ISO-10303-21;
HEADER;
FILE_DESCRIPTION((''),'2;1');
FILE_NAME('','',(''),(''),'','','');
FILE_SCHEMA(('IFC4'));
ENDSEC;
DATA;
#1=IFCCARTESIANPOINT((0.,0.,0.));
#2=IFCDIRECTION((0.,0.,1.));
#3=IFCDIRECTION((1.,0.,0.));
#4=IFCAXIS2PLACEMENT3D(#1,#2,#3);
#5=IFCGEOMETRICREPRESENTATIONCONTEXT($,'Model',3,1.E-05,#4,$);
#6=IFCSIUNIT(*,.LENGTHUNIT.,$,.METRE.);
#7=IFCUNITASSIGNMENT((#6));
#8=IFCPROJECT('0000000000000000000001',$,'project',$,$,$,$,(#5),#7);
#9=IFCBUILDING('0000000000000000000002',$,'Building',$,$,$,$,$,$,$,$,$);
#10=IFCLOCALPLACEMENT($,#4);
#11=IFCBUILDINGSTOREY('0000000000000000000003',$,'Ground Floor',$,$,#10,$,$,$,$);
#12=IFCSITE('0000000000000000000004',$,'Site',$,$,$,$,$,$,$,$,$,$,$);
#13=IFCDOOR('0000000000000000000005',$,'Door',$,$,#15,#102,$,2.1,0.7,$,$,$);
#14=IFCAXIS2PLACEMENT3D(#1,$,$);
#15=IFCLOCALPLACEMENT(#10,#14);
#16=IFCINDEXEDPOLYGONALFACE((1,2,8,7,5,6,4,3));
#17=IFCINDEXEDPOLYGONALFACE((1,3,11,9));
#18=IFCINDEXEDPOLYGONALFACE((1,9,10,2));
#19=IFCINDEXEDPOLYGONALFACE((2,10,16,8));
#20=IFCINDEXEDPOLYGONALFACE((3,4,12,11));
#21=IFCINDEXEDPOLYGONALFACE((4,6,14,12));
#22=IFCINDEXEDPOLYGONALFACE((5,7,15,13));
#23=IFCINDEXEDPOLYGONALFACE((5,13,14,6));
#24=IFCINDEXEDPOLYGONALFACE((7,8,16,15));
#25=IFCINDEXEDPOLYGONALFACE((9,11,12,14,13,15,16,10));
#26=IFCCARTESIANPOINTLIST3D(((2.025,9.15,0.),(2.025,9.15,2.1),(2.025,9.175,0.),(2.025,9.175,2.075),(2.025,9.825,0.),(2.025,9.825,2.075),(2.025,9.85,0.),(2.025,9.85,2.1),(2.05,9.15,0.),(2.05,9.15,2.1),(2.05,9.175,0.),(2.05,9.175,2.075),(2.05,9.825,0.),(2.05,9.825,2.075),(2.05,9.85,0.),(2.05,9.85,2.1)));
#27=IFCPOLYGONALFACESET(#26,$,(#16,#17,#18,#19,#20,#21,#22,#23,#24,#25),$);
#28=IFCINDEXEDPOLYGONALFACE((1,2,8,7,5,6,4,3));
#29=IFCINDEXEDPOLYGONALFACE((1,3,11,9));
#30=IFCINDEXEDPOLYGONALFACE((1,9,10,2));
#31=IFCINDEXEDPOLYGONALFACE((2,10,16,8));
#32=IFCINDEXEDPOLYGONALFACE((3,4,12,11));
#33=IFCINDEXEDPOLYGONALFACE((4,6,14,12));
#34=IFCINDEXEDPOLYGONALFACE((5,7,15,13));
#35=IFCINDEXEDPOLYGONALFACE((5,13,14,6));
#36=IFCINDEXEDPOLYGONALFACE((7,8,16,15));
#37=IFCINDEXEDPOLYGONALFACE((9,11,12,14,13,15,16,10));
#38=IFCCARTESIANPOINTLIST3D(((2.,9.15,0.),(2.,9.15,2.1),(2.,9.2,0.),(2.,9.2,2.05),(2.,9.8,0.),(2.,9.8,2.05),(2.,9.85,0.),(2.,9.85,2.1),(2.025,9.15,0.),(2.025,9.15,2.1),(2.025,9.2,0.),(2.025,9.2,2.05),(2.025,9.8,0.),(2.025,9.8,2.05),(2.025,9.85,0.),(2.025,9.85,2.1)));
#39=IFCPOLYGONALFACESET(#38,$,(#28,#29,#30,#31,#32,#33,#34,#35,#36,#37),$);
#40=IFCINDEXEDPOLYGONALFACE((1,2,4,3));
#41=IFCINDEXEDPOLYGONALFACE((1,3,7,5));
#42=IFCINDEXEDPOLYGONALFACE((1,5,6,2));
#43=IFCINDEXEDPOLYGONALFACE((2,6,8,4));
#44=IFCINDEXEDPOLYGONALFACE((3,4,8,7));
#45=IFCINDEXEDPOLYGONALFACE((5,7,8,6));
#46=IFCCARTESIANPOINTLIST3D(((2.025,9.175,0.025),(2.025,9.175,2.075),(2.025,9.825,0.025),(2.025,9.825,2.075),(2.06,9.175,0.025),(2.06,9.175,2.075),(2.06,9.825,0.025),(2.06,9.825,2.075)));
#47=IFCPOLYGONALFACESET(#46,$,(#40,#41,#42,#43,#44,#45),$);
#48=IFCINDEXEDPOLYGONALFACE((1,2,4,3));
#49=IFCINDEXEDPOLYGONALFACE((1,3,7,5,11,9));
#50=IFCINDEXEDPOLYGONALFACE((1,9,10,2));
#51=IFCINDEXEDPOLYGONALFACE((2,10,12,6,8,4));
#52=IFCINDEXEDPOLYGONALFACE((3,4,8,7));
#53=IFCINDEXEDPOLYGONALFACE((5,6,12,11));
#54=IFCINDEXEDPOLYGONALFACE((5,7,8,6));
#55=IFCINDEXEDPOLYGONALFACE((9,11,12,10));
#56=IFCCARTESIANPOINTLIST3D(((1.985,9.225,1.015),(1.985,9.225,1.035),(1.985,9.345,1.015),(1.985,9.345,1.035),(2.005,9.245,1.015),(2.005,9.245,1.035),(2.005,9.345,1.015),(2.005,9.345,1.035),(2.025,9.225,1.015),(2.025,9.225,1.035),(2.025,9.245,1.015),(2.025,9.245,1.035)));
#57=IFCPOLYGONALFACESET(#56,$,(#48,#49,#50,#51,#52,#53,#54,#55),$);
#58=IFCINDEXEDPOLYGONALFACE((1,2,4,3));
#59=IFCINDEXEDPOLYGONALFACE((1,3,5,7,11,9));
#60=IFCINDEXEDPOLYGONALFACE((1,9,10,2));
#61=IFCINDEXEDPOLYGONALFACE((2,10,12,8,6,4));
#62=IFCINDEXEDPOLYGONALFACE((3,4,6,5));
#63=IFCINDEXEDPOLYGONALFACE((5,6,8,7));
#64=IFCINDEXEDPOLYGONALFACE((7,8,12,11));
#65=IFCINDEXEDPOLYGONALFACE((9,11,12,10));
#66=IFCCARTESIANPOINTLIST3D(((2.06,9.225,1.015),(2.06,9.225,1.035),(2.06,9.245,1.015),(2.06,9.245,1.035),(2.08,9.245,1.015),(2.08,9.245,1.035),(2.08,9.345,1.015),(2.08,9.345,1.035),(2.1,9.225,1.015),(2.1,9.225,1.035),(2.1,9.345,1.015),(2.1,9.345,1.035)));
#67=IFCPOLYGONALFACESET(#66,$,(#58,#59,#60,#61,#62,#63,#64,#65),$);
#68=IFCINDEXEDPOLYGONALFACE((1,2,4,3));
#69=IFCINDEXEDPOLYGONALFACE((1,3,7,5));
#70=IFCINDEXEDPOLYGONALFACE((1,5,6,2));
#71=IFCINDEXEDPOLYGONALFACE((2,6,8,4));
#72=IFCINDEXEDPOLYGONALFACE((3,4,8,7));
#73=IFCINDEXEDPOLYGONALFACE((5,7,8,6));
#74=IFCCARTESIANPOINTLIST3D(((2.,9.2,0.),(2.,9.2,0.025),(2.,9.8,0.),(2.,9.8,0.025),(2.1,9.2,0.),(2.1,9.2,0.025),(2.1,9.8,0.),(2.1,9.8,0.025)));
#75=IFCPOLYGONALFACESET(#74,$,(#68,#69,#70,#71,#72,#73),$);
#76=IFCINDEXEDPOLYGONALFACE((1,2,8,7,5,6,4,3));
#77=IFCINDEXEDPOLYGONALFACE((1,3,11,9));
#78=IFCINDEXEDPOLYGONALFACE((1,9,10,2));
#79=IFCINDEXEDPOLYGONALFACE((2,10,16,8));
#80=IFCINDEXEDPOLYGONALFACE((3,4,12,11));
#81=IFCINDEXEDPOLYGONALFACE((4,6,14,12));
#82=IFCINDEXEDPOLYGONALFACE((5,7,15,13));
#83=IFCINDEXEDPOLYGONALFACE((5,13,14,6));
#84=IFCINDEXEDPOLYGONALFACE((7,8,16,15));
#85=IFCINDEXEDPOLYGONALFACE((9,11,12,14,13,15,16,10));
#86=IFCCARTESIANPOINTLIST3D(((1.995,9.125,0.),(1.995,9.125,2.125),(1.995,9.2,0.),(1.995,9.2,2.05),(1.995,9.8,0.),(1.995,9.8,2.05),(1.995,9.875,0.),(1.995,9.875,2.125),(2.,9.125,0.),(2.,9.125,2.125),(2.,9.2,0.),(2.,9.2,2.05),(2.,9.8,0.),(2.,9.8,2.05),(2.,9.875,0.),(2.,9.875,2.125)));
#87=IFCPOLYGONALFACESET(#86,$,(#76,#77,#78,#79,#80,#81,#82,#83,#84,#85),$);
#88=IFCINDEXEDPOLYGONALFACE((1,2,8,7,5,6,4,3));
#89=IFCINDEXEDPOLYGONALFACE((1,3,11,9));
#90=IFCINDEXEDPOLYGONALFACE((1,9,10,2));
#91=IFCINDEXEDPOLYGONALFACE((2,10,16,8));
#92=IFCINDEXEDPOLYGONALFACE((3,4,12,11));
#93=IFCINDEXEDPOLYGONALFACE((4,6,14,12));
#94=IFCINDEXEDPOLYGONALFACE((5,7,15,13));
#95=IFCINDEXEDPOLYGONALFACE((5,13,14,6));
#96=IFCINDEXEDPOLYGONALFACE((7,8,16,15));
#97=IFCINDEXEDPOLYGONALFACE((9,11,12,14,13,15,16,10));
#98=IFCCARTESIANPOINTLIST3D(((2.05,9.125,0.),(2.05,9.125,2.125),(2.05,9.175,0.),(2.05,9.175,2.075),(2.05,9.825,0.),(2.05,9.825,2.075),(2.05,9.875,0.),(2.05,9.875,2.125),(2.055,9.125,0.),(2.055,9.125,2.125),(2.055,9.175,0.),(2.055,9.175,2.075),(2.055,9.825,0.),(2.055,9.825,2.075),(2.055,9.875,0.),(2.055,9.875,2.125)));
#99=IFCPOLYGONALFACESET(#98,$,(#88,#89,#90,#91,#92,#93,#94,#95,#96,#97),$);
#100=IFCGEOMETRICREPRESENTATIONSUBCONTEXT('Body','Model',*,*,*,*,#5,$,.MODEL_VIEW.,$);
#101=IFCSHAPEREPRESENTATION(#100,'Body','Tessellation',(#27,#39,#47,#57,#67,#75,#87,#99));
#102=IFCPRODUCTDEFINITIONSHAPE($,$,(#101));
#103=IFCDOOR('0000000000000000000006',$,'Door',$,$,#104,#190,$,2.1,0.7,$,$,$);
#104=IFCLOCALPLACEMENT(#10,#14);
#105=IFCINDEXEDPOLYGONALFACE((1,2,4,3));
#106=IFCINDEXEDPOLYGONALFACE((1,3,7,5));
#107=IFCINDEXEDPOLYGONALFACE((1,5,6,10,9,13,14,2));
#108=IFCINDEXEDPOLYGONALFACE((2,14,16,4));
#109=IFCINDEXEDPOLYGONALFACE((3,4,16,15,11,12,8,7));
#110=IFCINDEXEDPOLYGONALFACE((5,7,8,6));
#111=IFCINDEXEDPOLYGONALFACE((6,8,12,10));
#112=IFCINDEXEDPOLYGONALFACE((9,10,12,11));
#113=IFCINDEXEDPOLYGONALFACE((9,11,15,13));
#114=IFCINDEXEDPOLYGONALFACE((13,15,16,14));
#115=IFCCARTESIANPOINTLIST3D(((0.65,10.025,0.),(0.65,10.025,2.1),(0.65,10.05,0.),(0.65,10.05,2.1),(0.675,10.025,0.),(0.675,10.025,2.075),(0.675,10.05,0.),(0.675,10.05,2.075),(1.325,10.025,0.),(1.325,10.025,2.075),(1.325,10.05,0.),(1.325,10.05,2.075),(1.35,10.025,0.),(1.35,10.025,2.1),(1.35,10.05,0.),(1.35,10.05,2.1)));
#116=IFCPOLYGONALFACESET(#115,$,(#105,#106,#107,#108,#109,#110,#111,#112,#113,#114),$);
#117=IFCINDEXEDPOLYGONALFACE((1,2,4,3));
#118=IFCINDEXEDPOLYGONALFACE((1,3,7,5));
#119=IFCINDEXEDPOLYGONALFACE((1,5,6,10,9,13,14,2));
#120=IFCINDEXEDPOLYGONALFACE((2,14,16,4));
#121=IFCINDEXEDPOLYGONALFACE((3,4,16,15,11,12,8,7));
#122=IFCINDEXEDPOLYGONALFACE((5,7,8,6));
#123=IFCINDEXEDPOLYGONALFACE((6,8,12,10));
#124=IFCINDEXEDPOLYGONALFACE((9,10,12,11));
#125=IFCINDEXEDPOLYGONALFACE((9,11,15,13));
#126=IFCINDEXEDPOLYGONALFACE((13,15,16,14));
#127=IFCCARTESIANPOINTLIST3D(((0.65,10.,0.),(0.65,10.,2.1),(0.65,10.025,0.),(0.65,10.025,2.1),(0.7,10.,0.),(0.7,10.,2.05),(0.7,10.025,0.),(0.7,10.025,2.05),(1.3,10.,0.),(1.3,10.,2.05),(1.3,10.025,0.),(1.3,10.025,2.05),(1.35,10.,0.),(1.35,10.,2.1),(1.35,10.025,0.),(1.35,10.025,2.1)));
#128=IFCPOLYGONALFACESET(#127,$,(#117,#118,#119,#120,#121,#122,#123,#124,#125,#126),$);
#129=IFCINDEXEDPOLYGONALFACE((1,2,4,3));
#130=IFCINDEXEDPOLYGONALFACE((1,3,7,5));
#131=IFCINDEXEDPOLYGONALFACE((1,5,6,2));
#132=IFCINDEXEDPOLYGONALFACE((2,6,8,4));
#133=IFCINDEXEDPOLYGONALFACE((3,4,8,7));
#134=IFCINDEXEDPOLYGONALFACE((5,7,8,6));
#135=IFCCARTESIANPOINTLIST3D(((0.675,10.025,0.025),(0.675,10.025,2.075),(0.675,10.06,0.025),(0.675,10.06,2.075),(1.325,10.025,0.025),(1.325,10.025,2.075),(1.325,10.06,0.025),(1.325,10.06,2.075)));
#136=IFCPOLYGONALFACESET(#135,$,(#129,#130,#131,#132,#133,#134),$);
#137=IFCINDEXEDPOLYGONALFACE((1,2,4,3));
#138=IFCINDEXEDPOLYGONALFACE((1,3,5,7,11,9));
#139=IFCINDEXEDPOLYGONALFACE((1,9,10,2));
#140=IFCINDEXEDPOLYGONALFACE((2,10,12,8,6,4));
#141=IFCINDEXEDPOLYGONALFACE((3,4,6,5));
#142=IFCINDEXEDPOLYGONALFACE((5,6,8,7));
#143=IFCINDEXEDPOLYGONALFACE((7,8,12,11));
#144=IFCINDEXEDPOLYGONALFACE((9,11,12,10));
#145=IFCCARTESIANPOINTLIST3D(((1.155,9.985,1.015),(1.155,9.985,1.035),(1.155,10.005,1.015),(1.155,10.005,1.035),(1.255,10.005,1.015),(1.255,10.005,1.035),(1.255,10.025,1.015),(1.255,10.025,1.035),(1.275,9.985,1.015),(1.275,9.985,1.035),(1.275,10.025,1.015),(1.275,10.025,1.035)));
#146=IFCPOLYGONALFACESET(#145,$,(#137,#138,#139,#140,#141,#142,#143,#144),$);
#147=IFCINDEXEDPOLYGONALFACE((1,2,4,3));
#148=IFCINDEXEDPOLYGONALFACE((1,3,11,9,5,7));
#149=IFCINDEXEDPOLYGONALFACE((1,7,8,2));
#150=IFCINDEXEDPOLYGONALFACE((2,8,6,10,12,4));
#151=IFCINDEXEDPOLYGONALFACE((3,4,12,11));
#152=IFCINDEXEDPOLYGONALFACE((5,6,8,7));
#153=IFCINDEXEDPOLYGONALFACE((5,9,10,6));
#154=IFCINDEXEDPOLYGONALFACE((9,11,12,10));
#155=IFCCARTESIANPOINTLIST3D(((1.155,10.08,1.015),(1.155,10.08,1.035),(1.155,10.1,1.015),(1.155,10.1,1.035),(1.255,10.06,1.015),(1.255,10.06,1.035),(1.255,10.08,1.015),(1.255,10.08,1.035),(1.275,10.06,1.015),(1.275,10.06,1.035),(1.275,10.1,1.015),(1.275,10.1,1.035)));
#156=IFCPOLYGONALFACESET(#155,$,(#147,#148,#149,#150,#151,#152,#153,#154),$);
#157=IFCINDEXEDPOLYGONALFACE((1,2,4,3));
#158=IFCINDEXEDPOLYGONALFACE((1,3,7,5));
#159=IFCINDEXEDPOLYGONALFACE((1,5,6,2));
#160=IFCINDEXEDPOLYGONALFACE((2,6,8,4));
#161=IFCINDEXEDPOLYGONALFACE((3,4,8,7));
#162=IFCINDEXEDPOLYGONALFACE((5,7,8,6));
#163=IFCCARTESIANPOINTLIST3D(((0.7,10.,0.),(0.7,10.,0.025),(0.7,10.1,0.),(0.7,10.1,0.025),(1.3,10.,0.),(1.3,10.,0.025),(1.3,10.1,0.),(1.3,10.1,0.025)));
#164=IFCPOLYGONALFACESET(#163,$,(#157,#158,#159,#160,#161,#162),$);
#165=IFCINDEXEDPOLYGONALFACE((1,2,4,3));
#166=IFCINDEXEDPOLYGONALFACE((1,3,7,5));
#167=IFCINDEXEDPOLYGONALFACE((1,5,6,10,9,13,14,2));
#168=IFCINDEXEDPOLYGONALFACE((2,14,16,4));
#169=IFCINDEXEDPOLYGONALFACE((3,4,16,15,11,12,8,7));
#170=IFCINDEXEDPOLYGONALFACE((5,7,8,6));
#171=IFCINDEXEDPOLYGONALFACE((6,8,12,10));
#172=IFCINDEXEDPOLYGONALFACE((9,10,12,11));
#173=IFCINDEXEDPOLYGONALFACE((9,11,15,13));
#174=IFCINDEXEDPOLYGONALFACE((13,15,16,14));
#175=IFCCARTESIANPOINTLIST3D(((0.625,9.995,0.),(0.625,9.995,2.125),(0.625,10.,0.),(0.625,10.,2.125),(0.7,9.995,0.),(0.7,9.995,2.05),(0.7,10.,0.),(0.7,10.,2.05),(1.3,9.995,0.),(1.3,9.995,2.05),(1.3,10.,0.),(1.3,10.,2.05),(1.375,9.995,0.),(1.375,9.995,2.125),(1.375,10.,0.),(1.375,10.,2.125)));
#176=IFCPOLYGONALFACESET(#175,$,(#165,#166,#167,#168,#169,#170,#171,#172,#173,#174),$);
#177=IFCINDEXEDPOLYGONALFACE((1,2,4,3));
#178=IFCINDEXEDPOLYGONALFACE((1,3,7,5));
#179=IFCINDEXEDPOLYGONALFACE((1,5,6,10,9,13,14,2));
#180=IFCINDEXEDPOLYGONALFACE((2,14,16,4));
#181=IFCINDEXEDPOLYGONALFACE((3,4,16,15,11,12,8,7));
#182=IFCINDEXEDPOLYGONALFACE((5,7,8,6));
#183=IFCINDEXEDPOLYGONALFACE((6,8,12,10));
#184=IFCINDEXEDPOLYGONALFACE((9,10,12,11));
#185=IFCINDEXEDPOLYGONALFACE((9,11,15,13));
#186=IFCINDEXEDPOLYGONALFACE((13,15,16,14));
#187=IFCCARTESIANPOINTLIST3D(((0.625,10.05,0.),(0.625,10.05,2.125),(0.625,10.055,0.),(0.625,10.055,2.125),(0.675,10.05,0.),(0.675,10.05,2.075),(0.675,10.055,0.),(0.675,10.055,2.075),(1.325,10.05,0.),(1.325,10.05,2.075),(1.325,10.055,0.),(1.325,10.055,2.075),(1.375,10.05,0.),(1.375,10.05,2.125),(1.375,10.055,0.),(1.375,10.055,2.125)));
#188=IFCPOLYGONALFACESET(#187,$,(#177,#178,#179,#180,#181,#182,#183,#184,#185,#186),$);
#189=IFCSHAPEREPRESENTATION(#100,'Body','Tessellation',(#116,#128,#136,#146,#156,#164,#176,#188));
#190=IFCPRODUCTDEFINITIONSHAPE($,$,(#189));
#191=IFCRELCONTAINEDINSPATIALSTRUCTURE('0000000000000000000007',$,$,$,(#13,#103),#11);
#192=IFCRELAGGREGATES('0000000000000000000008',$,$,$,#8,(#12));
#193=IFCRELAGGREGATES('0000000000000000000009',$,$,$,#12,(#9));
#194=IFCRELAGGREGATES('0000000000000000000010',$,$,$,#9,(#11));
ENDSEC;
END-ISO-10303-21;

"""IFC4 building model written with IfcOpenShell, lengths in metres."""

from ifc_helpers import new_model, si_unit, frame, origin_with_axes, place, context, subcontext, project, spatial, line, indexed_curve, outline, extrude, element, save


model = new_model("IFC4")

# Units and contexts
model_context = context("Model", 3, precision=1e-05, world=origin_with_axes())
body_context = subcontext(model_context, "Body", "Model", "MODEL_VIEW")
ifc_project = project(units=[si_unit("LENGTHUNIT", "METRE")], contexts=[model_context])

# Site, building, storey
site = spatial("IfcSite", under=ifc_project, Name="Site")
building = spatial("IfcBuilding", under=site, Name="Building")
storey_placement = place(None, origin_with_axes())
storey = spatial("IfcBuildingStorey", under=building, at=storey_placement, Name="Ground Floor")

# Doors
door_1_placement = place(storey_placement, frame((2.0, 9.85, 0.0), z_axis=(0.0, 0.0, 1.0), x_axis=(0.0, -1.0, 0.0)))
element("IfcDoor", 1, at=door_1_placement, inside=storey, Name="Door", OverallHeight=2.1, OverallWidth=0.7, context=body_context, shape_type="SweptSolid", body=[
    extrude(outline(indexed_curve([(0.0, 0.0), (0.0, 2.1), (0.7, 2.1), (0.7, 0.0), (0.675, 0.0), (0.675, 2.075), (0.025, 2.075), (0.025, 0.0)], segments=[line(1, 2, 3, 4, 5, 6, 7, 8, 1)])), frame((0.0, 0.025, 0.0), z_axis=(0.0, -1.0, 0.0), x_axis=(1.0, 0.0, 0.0)), (0.0, 0.0, -1.0), 0.025),
    extrude(outline(indexed_curve([(0.0, 0.0), (0.0, 2.1), (0.7, 2.1), (0.7, 0.0), (0.65, 0.0), (0.65, 2.05), (0.05, 2.05), (0.05, 0.0)], segments=[line(1, 2, 3, 4, 5, 6, 7, 8, 1)])), frame((0.0, 0.0, 0.0), z_axis=(0.0, -1.0, 0.0), x_axis=(1.0, 0.0, 0.0)), (0.0, 0.0, -1.0), 0.025),
    extrude(outline(indexed_curve([(0.0, 0.0), (0.65, 0.0), (0.65, 0.035), (0.0, 0.035)], segments=[line(1, 2, 3, 4, 1)])), frame((0.025, 0.025, 0.025), z_axis=(0.0, 0.0, 1.0), x_axis=(1.0, 0.0, 0.0)), (0.0, 0.0, 1.0), 2.05),
    extrude(outline(indexed_curve([(0.0, 0.0), (0.0, -0.04), (-0.12, -0.04), (-0.12, -0.02), (-0.02, -0.02), (-0.02, 0.0)], segments=[line(1, 2, 3, 4, 5, 6, 1)])), frame((0.625, 0.025, 1.015), z_axis=(0.0, 0.0, 1.0), x_axis=(1.0, 0.0, 0.0)), (0.0, 0.0, 1.0), 0.02),
    extrude(outline(indexed_curve([(0.0, 0.0), (0.0, 0.04), (-0.12, 0.04), (-0.12, 0.02), (-0.02, 0.02), (-0.02, 0.0)], segments=[line(1, 2, 3, 4, 5, 6, 1)])), frame((0.625, 0.06, 1.015), z_axis=(0.0, 0.0, 1.0), x_axis=(1.0, 0.0, 0.0)), (0.0, 0.0, 1.0), 0.02),
    extrude(outline(indexed_curve([(0.0, 0.0), (0.6, 0.0), (0.6, 0.1), (0.0, 0.1)], segments=[line(1, 2, 3, 4, 1)])), frame((0.05, 0.0, 0.0), z_axis=(0.0, 0.0, 1.0), x_axis=(1.0, 0.0, 0.0)), (0.0, 0.0, 1.0), 0.025),
    extrude(outline(indexed_curve([(0.0, 0.0), (0.0, 2.125), (0.75, 2.125), (0.75, 0.0), (0.675, 0.0), (0.675, 2.05), (0.075, 2.05), (0.075, 0.0)], segments=[line(1, 2, 3, 4, 5, 6, 7, 8, 1)])), frame((-0.025, -0.005, 0.0), z_axis=(0.0, -1.0, 0.0), x_axis=(1.0, 0.0, 0.0)), (0.0, 0.0, -1.0), 0.005),
    extrude(outline(indexed_curve([(0.0, 0.0), (0.0, 2.125), (0.75, 2.125), (0.75, 0.0), (0.7, 0.0), (0.7, 2.075), (0.05, 2.075), (0.05, 0.0)], segments=[line(1, 2, 3, 4, 5, 6, 7, 8, 1)])), frame((-0.025, 0.05, 0.0), z_axis=(0.0, -1.0, 0.0), x_axis=(1.0, 0.0, 0.0)), (0.0, 0.0, -1.0), 0.005),
])
door_2_placement = place(storey_placement, frame((0.65, 10.0, 0.0), z_axis=(0.0, 0.0, 1.0), x_axis=(1.0, 0.0, 0.0)))
element("IfcDoor", 2, at=door_2_placement, inside=storey, Name="Door", OverallHeight=2.1, OverallWidth=0.7, context=body_context, shape_type="SweptSolid", body=[
    extrude(outline(indexed_curve([(0.0, 0.0), (0.0, 2.1), (0.7, 2.1), (0.7, 0.0), (0.675, 0.0), (0.675, 2.075), (0.025, 2.075), (0.025, 0.0)], segments=[line(1, 2, 3, 4, 5, 6, 7, 8, 1)])), frame((0.0, 0.025, 0.0), z_axis=(0.0, -1.0, 0.0), x_axis=(1.0, 0.0, 0.0)), (0.0, 0.0, -1.0), 0.025),
    extrude(outline(indexed_curve([(0.0, 0.0), (0.0, 2.1), (0.7, 2.1), (0.7, 0.0), (0.65, 0.0), (0.65, 2.05), (0.05, 2.05), (0.05, 0.0)], segments=[line(1, 2, 3, 4, 5, 6, 7, 8, 1)])), frame((0.0, 0.0, 0.0), z_axis=(0.0, -1.0, 0.0), x_axis=(1.0, 0.0, 0.0)), (0.0, 0.0, -1.0), 0.025),
    extrude(outline(indexed_curve([(0.0, 0.0), (0.65, 0.0), (0.65, 0.035), (0.0, 0.035)], segments=[line(1, 2, 3, 4, 1)])), frame((0.025, 0.025, 0.025), z_axis=(0.0, 0.0, 1.0), x_axis=(1.0, 0.0, 0.0)), (0.0, 0.0, 1.0), 2.05),
    extrude(outline(indexed_curve([(0.0, 0.0), (0.0, -0.04), (-0.12, -0.04), (-0.12, -0.02), (-0.02, -0.02), (-0.02, 0.0)], segments=[line(1, 2, 3, 4, 5, 6, 1)])), frame((0.625, 0.025, 1.015), z_axis=(0.0, 0.0, 1.0), x_axis=(1.0, 0.0, 0.0)), (0.0, 0.0, 1.0), 0.02),
    extrude(outline(indexed_curve([(0.0, 0.0), (0.0, 0.04), (-0.12, 0.04), (-0.12, 0.02), (-0.02, 0.02), (-0.02, 0.0)], segments=[line(1, 2, 3, 4, 5, 6, 1)])), frame((0.625, 0.06, 1.015), z_axis=(0.0, 0.0, 1.0), x_axis=(1.0, 0.0, 0.0)), (0.0, 0.0, 1.0), 0.02),
    extrude(outline(indexed_curve([(0.0, 0.0), (0.6, 0.0), (0.6, 0.1), (0.0, 0.1)], segments=[line(1, 2, 3, 4, 1)])), frame((0.05, 0.0, 0.0), z_axis=(0.0, 0.0, 1.0), x_axis=(1.0, 0.0, 0.0)), (0.0, 0.0, 1.0), 0.025),
    extrude(outline(indexed_curve([(0.0, 0.0), (0.0, 2.125), (0.75, 2.125), (0.75, 0.0), (0.675, 0.0), (0.675, 2.05), (0.075, 2.05), (0.075, 0.0)], segments=[line(1, 2, 3, 4, 5, 6, 7, 8, 1)])), frame((-0.025, -0.005, 0.0), z_axis=(0.0, -1.0, 0.0), x_axis=(1.0, 0.0, 0.0)), (0.0, 0.0, -1.0), 0.005),
    extrude(outline(indexed_curve([(0.0, 0.0), (0.0, 2.125), (0.75, 2.125), (0.75, 0.0), (0.7, 0.0), (0.7, 2.075), (0.05, 2.075), (0.05, 0.0)], segments=[line(1, 2, 3, 4, 5, 6, 7, 8, 1)])), frame((-0.025, 0.05, 0.0), z_axis=(0.0, -1.0, 0.0), x_axis=(1.0, 0.0, 0.0)), (0.0, 0.0, -1.0), 0.005),
])

save(model, "model.ifc")
